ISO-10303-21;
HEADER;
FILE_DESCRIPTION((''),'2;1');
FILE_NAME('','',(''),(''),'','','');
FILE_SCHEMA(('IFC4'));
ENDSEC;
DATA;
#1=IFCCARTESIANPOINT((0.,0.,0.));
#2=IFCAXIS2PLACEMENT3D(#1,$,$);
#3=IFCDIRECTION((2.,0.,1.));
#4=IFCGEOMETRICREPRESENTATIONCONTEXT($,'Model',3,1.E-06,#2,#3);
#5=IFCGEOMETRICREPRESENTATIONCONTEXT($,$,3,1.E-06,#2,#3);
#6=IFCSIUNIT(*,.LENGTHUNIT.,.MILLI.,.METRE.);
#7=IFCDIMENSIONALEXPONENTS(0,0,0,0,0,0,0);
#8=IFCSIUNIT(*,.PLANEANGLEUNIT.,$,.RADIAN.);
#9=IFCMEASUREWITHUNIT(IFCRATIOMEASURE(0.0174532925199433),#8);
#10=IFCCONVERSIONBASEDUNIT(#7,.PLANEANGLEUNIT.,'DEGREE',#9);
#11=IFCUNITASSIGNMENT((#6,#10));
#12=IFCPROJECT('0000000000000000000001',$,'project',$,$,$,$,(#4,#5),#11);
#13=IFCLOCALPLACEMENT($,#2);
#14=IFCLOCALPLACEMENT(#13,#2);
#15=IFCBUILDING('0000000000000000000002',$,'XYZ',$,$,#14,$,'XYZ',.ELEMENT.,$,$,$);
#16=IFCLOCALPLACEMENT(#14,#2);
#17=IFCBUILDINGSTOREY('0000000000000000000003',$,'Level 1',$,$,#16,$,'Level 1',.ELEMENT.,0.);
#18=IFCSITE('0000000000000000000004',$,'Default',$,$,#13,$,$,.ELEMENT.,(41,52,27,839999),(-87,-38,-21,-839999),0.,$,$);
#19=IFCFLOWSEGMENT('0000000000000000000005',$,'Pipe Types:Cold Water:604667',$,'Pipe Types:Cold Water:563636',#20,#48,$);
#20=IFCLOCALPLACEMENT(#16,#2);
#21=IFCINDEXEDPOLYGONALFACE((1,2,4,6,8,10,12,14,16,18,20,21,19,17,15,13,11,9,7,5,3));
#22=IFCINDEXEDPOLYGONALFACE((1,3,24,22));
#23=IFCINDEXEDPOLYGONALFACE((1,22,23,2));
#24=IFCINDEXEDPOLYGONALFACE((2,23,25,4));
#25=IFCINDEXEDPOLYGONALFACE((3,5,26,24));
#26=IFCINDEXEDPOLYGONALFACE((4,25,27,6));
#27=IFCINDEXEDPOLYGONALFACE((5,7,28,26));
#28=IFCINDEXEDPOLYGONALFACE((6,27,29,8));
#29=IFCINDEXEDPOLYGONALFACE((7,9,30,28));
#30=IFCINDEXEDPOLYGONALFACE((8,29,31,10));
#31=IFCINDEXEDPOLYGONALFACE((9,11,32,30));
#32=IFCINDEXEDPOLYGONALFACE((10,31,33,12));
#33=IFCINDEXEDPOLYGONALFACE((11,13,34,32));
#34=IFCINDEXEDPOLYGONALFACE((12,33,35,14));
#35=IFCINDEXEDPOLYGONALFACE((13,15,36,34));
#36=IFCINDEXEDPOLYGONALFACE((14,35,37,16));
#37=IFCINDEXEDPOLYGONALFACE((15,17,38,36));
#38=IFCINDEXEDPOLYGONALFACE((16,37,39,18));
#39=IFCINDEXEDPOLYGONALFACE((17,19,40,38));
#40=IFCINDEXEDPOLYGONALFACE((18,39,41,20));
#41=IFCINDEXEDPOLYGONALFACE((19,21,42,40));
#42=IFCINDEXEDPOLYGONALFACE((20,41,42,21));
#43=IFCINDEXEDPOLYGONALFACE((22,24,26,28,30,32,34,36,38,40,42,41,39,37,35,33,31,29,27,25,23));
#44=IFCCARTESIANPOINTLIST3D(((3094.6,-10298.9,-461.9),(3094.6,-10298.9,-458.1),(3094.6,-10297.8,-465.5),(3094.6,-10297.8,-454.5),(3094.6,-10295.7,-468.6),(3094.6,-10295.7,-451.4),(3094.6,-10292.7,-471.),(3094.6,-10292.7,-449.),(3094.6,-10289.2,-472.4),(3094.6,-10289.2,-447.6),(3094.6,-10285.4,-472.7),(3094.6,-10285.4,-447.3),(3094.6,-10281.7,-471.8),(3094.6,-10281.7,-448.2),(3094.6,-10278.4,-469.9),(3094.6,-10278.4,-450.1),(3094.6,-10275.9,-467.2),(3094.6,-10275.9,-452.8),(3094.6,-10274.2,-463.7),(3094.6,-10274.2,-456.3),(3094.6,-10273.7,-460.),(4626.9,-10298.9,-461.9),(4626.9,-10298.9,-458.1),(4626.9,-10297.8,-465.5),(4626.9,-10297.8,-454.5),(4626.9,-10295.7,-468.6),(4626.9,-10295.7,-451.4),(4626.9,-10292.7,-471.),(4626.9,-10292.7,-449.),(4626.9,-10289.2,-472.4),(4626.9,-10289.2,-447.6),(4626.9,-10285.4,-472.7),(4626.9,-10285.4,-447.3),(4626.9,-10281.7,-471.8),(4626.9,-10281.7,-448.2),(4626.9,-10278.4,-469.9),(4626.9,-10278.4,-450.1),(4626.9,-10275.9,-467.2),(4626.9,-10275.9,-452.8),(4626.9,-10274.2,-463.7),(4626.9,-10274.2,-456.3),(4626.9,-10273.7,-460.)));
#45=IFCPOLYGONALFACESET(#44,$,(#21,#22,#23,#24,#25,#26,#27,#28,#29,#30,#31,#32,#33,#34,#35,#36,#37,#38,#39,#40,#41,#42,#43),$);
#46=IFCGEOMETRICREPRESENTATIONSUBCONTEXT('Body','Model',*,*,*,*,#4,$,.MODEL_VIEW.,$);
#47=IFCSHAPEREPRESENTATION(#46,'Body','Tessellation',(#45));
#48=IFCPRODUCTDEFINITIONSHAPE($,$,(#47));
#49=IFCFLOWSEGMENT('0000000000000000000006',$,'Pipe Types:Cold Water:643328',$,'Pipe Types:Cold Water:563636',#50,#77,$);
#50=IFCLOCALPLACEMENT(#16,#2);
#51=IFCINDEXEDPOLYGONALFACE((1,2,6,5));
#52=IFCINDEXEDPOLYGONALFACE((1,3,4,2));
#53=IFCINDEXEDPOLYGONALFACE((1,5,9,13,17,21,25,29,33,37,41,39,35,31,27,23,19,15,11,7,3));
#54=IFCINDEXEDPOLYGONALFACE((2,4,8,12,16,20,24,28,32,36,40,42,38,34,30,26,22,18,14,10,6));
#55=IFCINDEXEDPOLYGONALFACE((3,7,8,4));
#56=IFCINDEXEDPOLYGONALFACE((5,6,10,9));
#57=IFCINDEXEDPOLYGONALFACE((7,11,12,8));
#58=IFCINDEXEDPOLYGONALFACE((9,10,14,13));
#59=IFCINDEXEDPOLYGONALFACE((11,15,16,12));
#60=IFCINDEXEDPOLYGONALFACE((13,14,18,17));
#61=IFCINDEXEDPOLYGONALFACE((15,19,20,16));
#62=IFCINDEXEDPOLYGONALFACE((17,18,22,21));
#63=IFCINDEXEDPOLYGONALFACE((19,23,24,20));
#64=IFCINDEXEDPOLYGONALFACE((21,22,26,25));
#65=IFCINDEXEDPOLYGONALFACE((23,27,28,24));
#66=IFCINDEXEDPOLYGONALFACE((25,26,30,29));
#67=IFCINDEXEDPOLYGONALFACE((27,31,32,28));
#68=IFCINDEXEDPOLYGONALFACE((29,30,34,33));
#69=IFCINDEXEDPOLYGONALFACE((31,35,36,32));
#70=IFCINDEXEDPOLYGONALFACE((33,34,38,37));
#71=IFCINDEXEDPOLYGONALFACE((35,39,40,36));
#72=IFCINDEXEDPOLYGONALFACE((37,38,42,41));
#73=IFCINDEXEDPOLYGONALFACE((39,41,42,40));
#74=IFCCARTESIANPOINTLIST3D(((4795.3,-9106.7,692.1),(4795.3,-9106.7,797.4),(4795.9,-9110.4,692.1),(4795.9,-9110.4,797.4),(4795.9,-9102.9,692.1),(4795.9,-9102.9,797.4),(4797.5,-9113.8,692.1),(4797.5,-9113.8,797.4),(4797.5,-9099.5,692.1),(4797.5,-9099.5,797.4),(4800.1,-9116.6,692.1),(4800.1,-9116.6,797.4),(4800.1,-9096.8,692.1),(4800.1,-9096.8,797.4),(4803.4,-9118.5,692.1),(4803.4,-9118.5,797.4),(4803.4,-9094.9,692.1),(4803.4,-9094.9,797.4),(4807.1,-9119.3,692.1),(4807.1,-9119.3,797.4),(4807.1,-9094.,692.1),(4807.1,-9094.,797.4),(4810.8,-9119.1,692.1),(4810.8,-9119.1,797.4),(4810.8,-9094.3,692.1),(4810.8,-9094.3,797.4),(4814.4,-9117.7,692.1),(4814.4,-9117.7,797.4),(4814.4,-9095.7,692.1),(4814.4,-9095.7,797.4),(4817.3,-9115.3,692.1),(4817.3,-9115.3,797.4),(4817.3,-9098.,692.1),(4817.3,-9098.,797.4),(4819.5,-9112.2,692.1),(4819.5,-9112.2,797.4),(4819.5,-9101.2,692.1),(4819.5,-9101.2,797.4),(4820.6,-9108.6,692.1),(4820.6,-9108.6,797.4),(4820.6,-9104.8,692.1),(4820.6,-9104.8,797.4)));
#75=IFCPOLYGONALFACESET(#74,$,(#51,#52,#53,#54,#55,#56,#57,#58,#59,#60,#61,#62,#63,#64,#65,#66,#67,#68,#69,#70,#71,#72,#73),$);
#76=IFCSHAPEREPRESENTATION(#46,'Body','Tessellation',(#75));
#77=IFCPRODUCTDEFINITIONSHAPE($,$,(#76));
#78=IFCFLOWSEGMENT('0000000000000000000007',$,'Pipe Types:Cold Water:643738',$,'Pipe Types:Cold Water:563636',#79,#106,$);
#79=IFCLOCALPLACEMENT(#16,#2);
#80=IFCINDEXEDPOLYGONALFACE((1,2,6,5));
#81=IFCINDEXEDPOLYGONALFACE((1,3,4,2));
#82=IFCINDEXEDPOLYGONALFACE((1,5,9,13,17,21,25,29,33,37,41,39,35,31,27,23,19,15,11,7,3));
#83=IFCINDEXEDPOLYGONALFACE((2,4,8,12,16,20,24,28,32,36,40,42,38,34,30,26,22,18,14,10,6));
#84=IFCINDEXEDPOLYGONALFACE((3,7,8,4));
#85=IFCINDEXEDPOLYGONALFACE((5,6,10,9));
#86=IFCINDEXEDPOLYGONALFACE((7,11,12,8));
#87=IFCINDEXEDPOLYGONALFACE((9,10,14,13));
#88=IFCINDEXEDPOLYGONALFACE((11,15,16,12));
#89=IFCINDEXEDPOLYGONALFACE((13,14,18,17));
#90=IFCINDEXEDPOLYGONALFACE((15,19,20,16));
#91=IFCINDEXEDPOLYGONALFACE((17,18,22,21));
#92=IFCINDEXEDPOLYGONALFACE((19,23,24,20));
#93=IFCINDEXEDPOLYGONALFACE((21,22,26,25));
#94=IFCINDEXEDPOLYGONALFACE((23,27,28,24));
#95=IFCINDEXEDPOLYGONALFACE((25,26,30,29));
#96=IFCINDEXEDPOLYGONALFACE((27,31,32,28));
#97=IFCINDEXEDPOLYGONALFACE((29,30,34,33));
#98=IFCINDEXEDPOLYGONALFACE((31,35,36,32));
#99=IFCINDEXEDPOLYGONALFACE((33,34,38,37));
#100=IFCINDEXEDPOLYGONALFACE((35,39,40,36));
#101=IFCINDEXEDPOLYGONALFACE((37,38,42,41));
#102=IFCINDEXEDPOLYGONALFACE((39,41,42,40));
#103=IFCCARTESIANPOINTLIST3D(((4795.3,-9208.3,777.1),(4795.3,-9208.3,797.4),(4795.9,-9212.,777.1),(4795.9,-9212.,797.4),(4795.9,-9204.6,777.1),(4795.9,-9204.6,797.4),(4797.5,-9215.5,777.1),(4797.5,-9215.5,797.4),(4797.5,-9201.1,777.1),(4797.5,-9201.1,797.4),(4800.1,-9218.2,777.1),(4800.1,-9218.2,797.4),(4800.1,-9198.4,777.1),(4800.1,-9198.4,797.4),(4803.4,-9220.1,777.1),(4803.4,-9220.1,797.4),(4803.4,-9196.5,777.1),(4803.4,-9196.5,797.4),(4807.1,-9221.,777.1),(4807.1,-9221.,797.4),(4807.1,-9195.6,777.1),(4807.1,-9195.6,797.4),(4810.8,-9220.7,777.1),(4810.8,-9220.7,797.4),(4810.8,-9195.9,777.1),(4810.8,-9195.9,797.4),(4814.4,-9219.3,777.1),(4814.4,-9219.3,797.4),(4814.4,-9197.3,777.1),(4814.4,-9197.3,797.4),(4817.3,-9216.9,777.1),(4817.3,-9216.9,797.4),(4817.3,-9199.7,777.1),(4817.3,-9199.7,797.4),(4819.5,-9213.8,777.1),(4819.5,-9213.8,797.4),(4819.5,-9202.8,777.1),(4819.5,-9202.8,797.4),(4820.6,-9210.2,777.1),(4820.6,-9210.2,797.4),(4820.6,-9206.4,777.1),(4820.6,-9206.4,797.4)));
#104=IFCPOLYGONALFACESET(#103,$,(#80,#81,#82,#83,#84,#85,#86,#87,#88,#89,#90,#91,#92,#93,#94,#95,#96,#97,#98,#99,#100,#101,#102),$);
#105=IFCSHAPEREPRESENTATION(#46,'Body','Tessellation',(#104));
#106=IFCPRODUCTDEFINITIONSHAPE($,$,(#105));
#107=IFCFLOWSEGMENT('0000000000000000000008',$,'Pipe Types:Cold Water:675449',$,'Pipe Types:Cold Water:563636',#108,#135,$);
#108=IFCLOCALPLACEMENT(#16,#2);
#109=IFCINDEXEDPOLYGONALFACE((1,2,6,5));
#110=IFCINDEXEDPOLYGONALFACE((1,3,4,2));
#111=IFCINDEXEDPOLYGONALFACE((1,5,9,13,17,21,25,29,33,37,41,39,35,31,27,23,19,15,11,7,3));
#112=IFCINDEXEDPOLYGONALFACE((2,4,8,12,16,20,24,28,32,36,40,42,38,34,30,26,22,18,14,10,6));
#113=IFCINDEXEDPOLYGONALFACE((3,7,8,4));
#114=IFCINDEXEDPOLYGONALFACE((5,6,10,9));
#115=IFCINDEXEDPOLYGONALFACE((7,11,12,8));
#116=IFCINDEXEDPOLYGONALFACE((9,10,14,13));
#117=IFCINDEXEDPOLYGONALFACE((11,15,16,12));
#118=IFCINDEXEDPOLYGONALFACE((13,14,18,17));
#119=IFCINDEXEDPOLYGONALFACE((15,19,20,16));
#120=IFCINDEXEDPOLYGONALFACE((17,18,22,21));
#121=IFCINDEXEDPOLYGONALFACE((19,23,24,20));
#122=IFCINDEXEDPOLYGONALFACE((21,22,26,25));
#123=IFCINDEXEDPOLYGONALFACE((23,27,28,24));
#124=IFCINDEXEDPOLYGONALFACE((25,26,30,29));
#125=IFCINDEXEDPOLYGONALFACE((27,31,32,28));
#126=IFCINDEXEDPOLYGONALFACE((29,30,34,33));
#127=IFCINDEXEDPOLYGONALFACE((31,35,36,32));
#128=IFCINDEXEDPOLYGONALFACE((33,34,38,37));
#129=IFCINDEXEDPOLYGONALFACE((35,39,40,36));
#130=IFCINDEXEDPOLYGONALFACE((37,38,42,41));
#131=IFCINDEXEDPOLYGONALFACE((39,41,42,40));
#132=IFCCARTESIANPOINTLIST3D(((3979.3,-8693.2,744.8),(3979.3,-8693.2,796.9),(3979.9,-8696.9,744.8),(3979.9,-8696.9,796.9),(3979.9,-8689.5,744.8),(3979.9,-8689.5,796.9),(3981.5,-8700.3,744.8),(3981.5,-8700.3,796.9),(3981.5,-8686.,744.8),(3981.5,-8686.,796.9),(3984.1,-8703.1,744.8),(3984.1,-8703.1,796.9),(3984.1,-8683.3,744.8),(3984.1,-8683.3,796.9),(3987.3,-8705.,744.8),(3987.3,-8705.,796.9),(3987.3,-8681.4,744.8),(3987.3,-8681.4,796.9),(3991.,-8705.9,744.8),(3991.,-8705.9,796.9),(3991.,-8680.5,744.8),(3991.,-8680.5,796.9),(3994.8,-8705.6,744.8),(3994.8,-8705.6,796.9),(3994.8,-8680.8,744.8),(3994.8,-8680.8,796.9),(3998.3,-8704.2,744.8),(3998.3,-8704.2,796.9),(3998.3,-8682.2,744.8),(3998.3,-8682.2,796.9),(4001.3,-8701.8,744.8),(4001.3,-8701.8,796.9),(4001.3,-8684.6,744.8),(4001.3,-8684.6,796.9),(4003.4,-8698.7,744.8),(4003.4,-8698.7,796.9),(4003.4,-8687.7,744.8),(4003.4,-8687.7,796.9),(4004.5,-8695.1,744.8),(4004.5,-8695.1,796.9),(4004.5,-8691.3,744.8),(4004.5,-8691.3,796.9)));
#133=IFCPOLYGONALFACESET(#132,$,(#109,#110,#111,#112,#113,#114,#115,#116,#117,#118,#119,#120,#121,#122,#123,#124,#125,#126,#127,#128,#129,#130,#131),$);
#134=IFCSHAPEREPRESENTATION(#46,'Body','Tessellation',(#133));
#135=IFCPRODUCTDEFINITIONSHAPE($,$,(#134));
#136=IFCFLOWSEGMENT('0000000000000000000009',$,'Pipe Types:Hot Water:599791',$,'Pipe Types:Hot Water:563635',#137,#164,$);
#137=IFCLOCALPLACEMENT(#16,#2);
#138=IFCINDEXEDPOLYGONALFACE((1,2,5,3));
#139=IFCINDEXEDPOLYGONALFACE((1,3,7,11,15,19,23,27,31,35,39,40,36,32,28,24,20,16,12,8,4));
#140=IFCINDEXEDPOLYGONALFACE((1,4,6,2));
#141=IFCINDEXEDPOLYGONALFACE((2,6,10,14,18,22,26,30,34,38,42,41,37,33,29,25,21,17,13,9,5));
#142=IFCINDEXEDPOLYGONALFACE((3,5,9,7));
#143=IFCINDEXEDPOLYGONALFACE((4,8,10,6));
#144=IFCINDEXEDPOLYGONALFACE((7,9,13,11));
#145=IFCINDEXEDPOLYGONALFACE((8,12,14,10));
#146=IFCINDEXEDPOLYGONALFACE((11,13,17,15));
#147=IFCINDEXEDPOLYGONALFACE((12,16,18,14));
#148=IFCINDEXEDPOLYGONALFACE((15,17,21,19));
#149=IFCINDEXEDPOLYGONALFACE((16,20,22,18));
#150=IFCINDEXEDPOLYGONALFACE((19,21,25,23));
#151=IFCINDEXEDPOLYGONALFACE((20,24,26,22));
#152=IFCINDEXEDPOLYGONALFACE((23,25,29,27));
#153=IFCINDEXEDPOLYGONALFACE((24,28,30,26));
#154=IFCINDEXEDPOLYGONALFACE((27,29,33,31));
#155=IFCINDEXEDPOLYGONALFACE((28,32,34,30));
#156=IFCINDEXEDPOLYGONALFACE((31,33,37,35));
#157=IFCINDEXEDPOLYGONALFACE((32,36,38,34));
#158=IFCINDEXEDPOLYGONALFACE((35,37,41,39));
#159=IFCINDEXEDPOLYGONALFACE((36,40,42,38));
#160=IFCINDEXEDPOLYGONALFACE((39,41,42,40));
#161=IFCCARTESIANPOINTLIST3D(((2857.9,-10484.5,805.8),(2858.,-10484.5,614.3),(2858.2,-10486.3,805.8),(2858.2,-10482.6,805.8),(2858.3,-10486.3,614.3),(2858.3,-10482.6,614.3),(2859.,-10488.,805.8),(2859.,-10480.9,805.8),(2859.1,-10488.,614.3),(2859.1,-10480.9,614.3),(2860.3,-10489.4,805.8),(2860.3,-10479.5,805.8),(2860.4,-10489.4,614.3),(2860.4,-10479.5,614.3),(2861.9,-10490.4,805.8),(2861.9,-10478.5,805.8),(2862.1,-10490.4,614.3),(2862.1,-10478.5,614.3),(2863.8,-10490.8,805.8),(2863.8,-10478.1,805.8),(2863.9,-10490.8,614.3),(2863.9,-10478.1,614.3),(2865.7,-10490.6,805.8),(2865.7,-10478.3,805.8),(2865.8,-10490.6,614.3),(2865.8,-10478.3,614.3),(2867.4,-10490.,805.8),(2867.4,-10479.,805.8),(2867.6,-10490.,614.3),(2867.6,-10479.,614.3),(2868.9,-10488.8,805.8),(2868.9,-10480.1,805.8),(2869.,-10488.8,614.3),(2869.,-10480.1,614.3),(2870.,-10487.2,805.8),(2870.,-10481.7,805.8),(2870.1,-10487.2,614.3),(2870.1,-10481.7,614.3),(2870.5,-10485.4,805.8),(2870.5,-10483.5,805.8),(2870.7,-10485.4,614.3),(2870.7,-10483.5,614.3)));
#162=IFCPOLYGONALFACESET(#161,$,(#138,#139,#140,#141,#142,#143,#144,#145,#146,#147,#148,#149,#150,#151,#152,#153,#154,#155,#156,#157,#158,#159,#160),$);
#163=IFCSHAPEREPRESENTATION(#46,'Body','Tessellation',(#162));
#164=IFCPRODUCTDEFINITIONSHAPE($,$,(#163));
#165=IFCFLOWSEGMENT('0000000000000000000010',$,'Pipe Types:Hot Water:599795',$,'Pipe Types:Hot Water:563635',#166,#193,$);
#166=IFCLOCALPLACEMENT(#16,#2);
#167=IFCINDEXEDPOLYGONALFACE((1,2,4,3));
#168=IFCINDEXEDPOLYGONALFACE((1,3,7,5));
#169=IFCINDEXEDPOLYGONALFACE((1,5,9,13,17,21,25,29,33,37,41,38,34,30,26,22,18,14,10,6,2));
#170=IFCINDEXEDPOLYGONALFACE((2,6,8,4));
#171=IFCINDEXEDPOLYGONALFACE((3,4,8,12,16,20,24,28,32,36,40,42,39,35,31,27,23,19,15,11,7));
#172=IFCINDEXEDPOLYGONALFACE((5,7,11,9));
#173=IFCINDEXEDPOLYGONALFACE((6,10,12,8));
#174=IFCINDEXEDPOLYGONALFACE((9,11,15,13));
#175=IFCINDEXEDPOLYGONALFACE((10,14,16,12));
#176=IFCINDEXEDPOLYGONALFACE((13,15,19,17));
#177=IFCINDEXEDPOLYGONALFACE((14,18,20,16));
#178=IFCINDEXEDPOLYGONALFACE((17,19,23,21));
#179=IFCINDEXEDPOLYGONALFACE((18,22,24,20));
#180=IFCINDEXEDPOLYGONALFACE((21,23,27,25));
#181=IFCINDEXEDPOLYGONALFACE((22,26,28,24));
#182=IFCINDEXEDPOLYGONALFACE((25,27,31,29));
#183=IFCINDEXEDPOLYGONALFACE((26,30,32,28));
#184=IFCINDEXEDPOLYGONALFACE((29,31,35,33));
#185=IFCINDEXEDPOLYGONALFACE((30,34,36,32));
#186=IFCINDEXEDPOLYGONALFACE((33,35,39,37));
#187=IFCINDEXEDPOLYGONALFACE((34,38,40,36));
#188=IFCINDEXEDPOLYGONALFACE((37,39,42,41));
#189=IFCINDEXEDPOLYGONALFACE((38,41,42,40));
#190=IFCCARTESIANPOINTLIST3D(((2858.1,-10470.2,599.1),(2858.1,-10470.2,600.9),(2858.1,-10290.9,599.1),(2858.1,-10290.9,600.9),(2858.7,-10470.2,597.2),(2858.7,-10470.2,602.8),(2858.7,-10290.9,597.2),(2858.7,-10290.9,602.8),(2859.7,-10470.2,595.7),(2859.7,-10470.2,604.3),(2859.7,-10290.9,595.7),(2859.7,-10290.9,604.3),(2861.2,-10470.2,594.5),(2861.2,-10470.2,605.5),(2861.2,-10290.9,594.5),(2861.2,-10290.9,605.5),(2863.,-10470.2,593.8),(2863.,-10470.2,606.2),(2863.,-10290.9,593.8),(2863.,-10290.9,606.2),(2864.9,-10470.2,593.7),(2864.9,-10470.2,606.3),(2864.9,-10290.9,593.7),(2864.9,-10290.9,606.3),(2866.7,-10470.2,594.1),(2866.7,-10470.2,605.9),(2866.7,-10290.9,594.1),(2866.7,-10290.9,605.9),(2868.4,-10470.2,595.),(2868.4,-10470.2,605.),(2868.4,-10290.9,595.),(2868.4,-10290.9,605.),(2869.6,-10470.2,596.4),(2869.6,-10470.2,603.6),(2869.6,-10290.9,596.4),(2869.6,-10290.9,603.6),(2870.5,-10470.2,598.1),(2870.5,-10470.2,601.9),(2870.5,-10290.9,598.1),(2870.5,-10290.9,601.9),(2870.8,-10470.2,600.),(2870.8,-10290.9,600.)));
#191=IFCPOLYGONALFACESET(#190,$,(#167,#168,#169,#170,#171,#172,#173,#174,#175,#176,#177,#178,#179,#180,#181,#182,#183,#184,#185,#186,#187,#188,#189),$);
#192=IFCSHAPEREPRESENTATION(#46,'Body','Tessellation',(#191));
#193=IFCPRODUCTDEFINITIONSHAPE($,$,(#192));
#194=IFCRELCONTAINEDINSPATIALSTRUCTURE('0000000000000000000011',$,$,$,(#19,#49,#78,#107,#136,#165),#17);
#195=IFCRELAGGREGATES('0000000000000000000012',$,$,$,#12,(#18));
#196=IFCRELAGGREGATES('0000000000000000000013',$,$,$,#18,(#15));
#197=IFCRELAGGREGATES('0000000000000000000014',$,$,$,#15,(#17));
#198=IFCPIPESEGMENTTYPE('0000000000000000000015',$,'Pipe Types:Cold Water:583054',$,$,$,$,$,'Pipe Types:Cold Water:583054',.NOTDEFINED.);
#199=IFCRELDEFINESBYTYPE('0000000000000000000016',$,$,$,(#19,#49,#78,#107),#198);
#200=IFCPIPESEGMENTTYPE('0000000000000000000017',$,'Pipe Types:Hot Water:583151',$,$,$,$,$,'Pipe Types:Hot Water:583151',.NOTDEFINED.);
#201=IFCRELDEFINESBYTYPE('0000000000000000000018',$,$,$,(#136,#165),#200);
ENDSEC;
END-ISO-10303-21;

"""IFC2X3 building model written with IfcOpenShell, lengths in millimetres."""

from ifc_helpers import new_model, entity, si_unit, converted_unit, direction, frame, frame_2d, origin, origin_2d_with_axis, place, context, subcontext, project, spatial, circle, extrude, type_object, element, save


model = new_model("IFC2X3")

# Units and contexts
model_context = context("Model", 3, precision=1e-06, world=origin(), true_north=direction((2.0, 0.0, 1.0)))
context_of_model = context(None, 3, precision=1e-06, world=origin(), true_north=direction((2.0, 0.0, 1.0)))
body_context = subcontext(model_context, "Body", "Model", "MODEL_VIEW")
ifc_project = project(units=[si_unit("LENGTHUNIT", "METRE", prefix="MILLI"), converted_unit("PLANEANGLEUNIT", "DEGREE", entity("IfcRatioMeasure", 0.0174532925199433), si_unit("PLANEANGLEUNIT", "RADIAN"), dimensions=[0, 0, 0, 0, 0, 0, 0])], contexts=[model_context, context_of_model])

# Site, building, storey
site_placement = place(None, origin())
site = spatial("IfcSite", under=ifc_project, at=site_placement, Name="Default", CompositionType="ELEMENT", RefLatitude=(41, 52, 27, 839999), RefLongitude=(-87, -38, -21, -839999), RefElevation=0.0)
building_placement = place(site_placement, origin())
building = spatial("IfcBuilding", under=site, at=building_placement, Name="XYZ", LongName="XYZ", CompositionType="ELEMENT")
storey_placement = place(building_placement, origin())
storey = spatial("IfcBuildingStorey", under=building, at=storey_placement, Name="Level 1", LongName="Level 1", CompositionType="ELEMENT", Elevation=0.0)

# Flow segments
pipe_segment_type_1 = type_object("IfcPipeSegmentType", Name="Pipe Types:Cold Water:583054", ElementType="Pipe Types:Cold Water:583054", PredefinedType="NOTDEFINED")
flow_segment_1_placement = place(storey_placement, origin())
element("IfcFlowSegment", 1, at=flow_segment_1_placement, inside=storey, type_object=pipe_segment_type_1, Name="Pipe Types:Cold Water:604667", ObjectType="Pipe Types:Cold Water:563636", context=body_context, shape_type="SweptSolid", body=[
    extrude(circle(Radius=12.7, at=frame_2d((0.0, 0.0), x_axis=(1.0, 0.0))), frame((3094.6, -10286.4, -460.0), z_axis=(1.0, 0.0, 0.0), x_axis=(0.0, 1.0, 0.0)), (0.0, 0.0, 1.0), 1532.3),
])
flow_segment_2_placement = place(storey_placement, origin())
element("IfcFlowSegment", 2, at=flow_segment_2_placement, inside=storey, type_object=pipe_segment_type_1, Name="Pipe Types:Cold Water:643328", ObjectType="Pipe Types:Cold Water:563636", context=body_context, shape_type="SweptSolid", body=[
    extrude(circle(Radius=12.7, at=origin_2d_with_axis()), frame((4808.0, -9106.7, 692.1), z_axis=(0.0, 0.0, 1.0), x_axis=(-1.0, 0.0, 0.0)), (0.0, 0.0, 1.0), 105.3),
])
flow_segment_3_placement = place(storey_placement, origin())
element("IfcFlowSegment", 3, at=flow_segment_3_placement, inside=storey, type_object=pipe_segment_type_1, Name="Pipe Types:Cold Water:643738", ObjectType="Pipe Types:Cold Water:563636", context=body_context, shape_type="SweptSolid", body=[
    extrude(circle(Radius=12.7, at=origin_2d_with_axis()), frame((4808.0, -9208.3, 777.1), z_axis=(0.0, 0.0, 1.0), x_axis=(-1.0, 0.0, 0.0)), (0.0, 0.0, 1.0), 20.3),
])
flow_segment_4_placement = place(storey_placement, origin())
element("IfcFlowSegment", 4, at=flow_segment_4_placement, inside=storey, type_object=pipe_segment_type_1, Name="Pipe Types:Cold Water:675449", ObjectType="Pipe Types:Cold Water:563636", context=body_context, shape_type="SweptSolid", body=[
    extrude(circle(Radius=12.7, at=frame_2d((0.0, 0.0), x_axis=(1.0, 0.0))), frame((3992.0, -8693.2, 744.8), z_axis=(0.0, 0.0, 1.0), x_axis=(-1.0, 0.0, 0.0)), (0.0, 0.0, 1.0), 52.1),
])
pipe_segment_type_2 = type_object("IfcPipeSegmentType", Name="Pipe Types:Hot Water:583151", ElementType="Pipe Types:Hot Water:583151", PredefinedType="NOTDEFINED")
flow_segment_5_placement = place(storey_placement, origin())
element("IfcFlowSegment", 5, at=flow_segment_5_placement, inside=storey, type_object=pipe_segment_type_2, Name="Pipe Types:Hot Water:599791", ObjectType="Pipe Types:Hot Water:563635", context=body_context, shape_type="SweptSolid", body=[
    extrude(circle(Radius=6.3, at=origin_2d_with_axis()), frame((2864.4, -10484.5, 614.3), z_axis=(-0.000645, 0.000001, 1.0), x_axis=(-1.0, 0.0, -0.000645)), (0.0, 0.0, 1.0), 191.5),
])
flow_segment_6_placement = place(storey_placement, origin())
element("IfcFlowSegment", 6, at=flow_segment_6_placement, inside=storey, type_object=pipe_segment_type_2, Name="Pipe Types:Hot Water:599795", ObjectType="Pipe Types:Hot Water:563635", context=body_context, shape_type="SweptSolid", body=[
    extrude(circle(Radius=6.3, at=origin_2d_with_axis()), frame((2864.4, -10470.2, 600.0), z_axis=(0.0, 1.0, 0.0), x_axis=(1.0, 0.0, 0.0)), (0.0, 0.0, 1.0), 179.2),
])

save(model, "model.ifc")
